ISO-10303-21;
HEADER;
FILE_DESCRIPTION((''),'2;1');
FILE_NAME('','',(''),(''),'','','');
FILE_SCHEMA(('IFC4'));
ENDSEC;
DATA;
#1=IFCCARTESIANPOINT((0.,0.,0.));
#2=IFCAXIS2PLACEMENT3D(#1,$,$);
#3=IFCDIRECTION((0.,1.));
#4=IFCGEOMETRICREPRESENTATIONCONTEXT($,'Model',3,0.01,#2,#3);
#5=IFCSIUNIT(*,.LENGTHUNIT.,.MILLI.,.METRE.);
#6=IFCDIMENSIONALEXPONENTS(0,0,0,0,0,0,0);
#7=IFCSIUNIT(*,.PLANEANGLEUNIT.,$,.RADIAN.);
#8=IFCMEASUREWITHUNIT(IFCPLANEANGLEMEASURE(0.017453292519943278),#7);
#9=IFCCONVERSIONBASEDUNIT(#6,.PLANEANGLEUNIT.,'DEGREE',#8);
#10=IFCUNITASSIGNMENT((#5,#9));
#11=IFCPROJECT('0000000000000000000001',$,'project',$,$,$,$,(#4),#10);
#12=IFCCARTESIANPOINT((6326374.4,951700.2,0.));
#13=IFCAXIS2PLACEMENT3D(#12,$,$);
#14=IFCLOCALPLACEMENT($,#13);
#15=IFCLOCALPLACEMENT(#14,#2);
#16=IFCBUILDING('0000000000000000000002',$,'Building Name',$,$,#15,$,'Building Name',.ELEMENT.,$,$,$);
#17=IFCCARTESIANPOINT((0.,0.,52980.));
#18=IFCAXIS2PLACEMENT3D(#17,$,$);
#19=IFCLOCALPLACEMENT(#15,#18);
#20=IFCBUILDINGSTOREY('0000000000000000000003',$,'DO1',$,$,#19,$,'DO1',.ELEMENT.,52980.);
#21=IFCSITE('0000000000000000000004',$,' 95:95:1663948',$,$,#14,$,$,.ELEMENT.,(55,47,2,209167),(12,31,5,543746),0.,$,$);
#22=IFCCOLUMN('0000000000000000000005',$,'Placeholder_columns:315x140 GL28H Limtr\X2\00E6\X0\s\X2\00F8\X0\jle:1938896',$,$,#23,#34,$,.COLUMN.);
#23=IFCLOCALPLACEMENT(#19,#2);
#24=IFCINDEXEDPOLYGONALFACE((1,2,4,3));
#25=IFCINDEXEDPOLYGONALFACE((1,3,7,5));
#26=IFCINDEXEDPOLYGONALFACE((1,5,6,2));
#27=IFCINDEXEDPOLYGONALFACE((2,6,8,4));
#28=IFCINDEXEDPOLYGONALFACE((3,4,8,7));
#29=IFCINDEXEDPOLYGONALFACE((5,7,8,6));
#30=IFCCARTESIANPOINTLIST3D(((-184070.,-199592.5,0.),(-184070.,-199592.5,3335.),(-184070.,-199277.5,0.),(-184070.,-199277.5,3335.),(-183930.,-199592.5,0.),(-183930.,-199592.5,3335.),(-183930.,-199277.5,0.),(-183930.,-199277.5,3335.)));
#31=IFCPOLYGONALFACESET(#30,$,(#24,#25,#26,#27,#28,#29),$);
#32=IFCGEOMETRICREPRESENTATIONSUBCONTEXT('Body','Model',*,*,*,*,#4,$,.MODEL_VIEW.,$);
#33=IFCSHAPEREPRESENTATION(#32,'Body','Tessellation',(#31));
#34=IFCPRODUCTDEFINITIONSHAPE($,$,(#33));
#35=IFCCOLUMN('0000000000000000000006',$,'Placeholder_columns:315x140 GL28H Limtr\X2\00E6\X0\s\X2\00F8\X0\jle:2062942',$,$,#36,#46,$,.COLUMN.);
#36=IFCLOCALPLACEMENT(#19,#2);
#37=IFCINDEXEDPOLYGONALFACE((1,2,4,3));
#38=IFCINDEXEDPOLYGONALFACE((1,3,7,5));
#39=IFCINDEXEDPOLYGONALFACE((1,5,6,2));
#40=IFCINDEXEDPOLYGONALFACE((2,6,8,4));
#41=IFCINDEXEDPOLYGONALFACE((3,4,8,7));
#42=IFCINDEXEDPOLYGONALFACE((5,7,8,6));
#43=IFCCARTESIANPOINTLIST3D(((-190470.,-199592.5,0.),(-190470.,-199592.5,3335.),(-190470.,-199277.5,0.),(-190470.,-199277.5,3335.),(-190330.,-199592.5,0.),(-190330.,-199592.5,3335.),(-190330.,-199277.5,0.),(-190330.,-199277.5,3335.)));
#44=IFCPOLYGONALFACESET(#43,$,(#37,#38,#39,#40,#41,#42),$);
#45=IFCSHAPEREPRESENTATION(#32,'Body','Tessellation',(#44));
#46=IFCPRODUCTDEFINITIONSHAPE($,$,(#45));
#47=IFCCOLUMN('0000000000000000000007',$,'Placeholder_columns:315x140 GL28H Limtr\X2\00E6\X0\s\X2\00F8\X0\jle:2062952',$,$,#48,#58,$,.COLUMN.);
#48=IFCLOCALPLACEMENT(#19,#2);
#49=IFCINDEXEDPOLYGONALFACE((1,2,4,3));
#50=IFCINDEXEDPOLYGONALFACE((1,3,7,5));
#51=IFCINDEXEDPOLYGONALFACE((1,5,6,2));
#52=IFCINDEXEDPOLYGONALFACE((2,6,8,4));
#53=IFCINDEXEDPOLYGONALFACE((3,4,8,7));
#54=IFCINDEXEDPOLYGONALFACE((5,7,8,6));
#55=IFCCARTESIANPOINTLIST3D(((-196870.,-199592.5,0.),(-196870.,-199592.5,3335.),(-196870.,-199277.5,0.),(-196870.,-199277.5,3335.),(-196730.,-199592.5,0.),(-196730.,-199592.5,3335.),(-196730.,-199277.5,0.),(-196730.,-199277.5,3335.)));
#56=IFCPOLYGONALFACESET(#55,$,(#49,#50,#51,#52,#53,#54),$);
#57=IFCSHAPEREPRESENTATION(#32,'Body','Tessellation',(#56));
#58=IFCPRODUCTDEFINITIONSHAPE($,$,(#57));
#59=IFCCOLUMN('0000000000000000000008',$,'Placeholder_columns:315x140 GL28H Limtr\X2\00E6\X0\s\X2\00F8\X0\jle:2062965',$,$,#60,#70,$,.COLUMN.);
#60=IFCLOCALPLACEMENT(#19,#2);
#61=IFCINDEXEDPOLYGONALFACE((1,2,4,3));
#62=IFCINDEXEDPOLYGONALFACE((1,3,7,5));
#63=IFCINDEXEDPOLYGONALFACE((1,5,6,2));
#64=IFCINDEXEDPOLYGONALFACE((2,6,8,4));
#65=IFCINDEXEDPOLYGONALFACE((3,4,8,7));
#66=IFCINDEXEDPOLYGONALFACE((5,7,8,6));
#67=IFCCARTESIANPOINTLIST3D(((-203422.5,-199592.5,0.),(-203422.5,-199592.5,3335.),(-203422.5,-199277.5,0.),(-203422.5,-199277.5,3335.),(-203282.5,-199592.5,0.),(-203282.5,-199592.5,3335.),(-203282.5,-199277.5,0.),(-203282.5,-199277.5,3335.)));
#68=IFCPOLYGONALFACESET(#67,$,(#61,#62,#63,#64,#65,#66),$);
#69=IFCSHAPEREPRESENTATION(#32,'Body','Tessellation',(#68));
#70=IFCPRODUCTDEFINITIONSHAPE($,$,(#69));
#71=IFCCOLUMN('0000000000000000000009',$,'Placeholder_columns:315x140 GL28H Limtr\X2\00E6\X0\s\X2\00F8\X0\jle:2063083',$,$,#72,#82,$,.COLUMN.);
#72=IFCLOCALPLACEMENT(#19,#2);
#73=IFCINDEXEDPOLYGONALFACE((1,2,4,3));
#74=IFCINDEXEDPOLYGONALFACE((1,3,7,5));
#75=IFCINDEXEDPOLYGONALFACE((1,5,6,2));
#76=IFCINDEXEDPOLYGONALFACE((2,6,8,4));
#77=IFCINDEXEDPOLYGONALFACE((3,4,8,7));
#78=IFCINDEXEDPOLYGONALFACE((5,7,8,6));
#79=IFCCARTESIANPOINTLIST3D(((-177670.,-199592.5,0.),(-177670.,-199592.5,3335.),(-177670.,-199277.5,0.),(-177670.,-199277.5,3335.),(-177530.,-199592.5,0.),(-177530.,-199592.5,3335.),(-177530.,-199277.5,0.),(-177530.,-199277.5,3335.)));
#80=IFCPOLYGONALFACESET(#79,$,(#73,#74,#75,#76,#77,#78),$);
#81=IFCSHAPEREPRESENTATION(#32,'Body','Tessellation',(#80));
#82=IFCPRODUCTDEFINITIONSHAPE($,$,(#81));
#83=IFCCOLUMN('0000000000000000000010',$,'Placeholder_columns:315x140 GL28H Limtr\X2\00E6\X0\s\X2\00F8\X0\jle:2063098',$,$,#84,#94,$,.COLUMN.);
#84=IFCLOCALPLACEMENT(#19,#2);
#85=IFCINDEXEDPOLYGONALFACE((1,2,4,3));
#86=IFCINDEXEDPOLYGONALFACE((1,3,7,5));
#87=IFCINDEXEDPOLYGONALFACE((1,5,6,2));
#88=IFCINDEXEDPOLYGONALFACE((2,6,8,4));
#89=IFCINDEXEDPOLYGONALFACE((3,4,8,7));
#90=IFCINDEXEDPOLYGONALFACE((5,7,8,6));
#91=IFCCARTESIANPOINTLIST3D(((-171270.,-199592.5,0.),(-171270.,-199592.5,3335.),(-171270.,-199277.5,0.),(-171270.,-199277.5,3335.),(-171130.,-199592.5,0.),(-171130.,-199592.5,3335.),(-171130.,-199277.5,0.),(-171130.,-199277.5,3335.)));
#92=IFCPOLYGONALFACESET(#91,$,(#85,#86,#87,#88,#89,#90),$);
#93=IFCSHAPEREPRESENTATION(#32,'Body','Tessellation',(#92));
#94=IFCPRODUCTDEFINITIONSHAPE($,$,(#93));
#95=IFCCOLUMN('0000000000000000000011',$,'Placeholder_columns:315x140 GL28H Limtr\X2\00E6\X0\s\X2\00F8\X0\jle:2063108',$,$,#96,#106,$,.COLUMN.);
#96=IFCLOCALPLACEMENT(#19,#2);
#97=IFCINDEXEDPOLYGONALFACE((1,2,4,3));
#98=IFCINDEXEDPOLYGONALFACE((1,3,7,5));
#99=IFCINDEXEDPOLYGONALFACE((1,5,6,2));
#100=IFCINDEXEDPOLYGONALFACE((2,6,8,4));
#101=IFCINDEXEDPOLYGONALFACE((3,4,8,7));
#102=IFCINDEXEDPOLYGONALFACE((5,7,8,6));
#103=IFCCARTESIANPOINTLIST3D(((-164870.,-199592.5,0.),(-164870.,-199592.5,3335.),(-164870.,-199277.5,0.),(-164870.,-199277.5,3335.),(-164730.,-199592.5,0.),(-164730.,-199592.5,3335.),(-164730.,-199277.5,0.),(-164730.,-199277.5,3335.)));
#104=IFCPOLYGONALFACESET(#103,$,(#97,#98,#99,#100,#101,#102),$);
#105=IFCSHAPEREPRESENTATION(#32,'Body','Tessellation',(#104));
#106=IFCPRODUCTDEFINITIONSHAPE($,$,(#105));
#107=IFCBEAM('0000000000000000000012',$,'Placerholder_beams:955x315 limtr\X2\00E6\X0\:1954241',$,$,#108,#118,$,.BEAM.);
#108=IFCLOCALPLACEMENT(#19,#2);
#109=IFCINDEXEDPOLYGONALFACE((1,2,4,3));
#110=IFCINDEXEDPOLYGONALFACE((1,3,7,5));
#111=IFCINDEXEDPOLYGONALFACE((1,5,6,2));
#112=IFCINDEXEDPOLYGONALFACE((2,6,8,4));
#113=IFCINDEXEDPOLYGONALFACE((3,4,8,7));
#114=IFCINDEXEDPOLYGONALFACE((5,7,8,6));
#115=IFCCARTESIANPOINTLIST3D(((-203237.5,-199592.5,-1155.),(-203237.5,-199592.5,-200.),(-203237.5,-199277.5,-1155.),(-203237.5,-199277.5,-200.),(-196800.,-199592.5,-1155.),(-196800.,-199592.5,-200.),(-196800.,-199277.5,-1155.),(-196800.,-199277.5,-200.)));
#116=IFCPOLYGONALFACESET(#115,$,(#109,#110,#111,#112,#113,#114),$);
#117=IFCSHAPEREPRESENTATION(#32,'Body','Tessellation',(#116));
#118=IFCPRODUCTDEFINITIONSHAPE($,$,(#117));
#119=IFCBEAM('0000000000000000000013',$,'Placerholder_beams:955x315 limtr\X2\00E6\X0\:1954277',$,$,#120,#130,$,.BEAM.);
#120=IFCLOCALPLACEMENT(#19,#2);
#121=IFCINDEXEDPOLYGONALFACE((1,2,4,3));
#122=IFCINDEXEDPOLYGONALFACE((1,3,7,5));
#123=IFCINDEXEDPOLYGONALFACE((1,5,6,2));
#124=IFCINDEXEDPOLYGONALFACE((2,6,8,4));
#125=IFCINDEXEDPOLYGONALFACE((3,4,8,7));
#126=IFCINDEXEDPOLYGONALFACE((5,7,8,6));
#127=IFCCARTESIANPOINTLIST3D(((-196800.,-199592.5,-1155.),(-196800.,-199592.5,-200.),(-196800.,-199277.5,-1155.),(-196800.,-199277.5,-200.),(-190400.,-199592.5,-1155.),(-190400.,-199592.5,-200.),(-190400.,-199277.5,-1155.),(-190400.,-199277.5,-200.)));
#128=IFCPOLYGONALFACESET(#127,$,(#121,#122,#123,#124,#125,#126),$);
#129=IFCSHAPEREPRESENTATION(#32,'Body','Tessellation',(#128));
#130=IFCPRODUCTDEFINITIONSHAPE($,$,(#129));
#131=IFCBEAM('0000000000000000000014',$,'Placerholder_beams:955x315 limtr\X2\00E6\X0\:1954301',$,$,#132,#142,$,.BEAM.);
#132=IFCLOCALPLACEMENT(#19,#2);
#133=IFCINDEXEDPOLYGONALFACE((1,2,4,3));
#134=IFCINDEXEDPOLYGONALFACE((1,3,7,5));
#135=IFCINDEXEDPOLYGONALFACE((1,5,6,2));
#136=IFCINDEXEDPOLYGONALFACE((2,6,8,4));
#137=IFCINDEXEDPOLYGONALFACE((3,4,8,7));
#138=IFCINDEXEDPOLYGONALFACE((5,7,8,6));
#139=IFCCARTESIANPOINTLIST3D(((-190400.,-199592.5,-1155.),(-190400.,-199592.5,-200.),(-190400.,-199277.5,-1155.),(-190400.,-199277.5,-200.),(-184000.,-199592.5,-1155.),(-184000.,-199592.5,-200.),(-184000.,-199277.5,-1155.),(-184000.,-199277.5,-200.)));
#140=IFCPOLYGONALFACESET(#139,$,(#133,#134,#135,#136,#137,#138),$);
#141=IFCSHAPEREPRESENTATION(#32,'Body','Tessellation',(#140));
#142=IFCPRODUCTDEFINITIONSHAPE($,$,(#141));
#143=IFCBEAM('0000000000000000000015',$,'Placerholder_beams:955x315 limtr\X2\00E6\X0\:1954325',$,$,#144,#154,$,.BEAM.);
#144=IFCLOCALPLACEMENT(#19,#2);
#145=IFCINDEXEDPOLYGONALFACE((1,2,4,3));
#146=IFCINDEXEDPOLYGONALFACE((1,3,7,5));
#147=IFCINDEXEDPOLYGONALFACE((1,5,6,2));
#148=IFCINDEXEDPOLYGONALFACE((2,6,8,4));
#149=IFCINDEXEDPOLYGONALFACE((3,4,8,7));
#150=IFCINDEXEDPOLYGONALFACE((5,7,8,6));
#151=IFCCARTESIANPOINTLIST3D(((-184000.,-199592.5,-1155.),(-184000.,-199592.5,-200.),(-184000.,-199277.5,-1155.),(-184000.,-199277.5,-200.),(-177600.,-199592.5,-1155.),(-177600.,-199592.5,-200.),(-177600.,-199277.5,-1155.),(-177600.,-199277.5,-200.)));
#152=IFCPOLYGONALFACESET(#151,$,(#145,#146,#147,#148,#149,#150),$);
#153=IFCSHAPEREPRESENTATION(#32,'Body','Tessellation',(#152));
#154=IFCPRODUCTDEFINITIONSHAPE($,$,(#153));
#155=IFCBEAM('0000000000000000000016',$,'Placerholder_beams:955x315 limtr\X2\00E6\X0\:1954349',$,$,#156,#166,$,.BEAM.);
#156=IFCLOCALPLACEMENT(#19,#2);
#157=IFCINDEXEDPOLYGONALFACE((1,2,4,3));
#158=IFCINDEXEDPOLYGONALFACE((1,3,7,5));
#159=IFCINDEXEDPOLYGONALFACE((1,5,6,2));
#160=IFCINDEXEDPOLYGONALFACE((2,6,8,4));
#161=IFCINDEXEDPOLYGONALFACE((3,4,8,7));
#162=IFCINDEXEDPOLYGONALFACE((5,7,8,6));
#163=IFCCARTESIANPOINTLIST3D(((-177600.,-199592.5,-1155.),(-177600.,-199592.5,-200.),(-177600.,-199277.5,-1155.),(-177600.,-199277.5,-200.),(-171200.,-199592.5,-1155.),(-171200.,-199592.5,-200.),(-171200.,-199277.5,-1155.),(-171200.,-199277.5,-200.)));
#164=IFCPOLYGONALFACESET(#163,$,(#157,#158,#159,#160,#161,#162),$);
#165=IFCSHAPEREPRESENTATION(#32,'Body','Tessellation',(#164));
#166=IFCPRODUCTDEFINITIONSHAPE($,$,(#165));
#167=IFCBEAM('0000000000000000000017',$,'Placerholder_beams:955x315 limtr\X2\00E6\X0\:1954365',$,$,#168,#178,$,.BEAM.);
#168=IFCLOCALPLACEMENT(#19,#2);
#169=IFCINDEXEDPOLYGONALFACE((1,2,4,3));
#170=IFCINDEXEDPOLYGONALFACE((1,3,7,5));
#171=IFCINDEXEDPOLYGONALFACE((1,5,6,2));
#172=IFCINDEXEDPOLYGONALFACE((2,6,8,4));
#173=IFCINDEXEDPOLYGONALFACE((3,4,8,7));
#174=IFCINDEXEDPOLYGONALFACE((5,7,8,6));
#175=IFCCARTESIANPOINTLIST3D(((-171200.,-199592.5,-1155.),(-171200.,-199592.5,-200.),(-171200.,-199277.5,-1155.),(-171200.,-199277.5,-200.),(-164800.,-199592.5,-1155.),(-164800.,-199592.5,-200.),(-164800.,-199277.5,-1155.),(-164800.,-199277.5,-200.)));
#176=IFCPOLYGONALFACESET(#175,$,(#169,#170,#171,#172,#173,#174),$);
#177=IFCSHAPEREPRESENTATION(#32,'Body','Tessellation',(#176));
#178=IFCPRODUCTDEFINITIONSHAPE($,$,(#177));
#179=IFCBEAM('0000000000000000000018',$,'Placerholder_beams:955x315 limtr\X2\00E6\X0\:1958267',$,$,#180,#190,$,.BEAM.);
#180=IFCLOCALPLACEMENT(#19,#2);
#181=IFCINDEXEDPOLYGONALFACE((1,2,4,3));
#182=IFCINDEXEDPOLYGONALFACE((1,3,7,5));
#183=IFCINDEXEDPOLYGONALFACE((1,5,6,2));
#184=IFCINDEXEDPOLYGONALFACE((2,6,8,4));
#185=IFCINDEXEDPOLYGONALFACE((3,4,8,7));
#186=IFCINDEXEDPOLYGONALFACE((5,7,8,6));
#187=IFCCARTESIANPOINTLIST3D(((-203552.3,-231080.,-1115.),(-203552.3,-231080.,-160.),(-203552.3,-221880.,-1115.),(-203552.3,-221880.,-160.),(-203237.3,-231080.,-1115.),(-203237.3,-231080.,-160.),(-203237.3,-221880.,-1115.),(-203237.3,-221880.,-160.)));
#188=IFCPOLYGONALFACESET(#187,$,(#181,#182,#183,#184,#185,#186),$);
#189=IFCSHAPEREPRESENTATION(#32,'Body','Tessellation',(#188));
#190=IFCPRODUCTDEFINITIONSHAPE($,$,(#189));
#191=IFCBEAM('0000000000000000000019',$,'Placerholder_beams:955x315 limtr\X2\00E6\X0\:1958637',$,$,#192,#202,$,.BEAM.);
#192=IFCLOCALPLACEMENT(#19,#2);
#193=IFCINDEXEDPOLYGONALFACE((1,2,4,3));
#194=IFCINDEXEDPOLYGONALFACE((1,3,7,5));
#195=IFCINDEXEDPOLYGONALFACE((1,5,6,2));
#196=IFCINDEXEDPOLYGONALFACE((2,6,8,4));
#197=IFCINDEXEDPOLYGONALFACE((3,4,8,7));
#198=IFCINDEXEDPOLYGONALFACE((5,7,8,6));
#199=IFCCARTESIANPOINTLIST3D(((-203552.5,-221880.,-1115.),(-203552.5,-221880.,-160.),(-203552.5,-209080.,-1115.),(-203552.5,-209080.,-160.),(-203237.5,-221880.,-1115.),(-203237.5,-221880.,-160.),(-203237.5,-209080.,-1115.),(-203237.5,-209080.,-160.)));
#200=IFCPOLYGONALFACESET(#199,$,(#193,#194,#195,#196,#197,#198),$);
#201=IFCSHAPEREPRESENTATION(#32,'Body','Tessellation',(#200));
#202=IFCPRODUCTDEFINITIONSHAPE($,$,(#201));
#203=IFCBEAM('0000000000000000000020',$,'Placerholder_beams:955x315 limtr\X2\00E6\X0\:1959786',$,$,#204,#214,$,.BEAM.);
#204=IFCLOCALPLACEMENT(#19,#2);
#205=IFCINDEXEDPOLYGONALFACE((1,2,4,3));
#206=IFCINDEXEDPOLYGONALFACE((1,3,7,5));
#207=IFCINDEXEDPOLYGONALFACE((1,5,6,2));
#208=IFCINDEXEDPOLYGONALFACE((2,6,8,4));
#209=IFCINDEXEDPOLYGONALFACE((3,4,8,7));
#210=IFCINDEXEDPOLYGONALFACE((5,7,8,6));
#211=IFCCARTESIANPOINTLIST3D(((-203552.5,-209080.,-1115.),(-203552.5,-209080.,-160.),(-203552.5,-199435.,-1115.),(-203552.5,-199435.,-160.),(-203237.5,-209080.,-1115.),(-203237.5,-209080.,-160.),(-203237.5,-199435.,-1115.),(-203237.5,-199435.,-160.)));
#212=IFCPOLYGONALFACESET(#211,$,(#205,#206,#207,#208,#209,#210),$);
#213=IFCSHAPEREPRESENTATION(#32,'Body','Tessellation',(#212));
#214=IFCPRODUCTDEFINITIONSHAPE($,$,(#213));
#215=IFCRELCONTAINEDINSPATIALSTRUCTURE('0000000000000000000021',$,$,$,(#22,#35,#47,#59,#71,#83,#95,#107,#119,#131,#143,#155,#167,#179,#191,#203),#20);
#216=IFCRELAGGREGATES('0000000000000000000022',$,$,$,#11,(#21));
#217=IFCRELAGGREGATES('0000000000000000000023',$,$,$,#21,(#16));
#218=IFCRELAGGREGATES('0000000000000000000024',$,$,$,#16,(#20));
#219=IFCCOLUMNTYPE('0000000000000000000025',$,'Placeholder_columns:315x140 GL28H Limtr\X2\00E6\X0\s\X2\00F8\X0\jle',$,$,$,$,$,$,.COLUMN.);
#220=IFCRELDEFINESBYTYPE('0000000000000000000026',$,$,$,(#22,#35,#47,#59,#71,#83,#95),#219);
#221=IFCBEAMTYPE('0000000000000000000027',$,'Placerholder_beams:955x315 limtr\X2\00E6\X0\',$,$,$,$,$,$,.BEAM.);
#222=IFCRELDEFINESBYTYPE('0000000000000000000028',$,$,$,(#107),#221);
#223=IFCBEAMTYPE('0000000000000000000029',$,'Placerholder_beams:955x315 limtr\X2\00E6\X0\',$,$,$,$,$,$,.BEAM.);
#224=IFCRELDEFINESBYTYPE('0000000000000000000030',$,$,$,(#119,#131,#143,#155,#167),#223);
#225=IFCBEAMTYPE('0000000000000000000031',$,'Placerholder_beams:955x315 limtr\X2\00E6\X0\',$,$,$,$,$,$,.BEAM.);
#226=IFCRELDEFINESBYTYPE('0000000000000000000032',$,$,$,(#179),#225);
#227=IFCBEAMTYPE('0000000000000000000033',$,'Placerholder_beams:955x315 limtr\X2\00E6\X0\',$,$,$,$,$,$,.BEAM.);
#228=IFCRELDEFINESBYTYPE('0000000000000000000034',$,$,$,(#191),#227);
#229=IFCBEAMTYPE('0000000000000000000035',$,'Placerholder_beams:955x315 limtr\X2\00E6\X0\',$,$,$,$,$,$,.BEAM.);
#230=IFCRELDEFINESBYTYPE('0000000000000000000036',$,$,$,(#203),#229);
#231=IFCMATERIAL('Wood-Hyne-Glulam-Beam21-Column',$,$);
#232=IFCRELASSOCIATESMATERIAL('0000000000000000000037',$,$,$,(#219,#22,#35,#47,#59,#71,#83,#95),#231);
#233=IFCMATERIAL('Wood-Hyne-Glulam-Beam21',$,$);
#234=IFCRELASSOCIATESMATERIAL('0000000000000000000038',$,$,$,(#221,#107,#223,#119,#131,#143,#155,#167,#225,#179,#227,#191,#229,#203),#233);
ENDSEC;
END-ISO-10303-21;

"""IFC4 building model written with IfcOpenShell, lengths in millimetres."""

from ifc_helpers import new_model, entity, si_unit, converted_unit, direction, frame, origin, place, context, subcontext, project, spatial, indexed_curve, outline, extrude, source, transform, mapped, material, type_object, type_shapes, element, save


model = new_model("IFC4")

# Units and contexts
model_context = context("Model", 3, precision=0.01, world=origin(), true_north=direction((0.0, 1.0)))
body_context = subcontext(model_context, "Body", "Model", "MODEL_VIEW")
ifc_project = project(units=[si_unit("LENGTHUNIT", "METRE", prefix="MILLI"), converted_unit("PLANEANGLEUNIT", "DEGREE", entity("IfcPlaneAngleMeasure", 0.017453292519943278), si_unit("PLANEANGLEUNIT", "RADIAN"), dimensions=[0, 0, 0, 0, 0, 0, 0])], contexts=[model_context])

# Site, building, storey
site_placement = place(None, frame((6326374.4, 951700.2, 0.0)))
site = spatial("IfcSite", under=ifc_project, at=site_placement, Name=" 95:95:1663948", CompositionType="ELEMENT", RefLatitude=(55, 47, 2, 209167), RefLongitude=(12, 31, 5, 543746), RefElevation=0.0)
building_placement = place(site_placement, origin())
building = spatial("IfcBuilding", under=site, at=building_placement, Name="Building Name", LongName="Building Name", CompositionType="ELEMENT")
storey_placement = place(building_placement, frame((0.0, 0.0, 52980.0)))
storey = spatial("IfcBuildingStorey", under=building, at=storey_placement, Name="DO1", LongName="DO1", CompositionType="ELEMENT", Elevation=52980.0)

# Columns
ifc_material_1 = material(Name="Wood-Hyne-Glulam-Beam21-Column")
column_type = type_object("IfcColumnType", Name="Placeholder_columns:315x140 GL28H Limtræsøjle", PredefinedType="COLUMN", material=ifc_material_1)
shared_shape_1 = source(origin(), body_context, "Body", "SweptSolid", [
    extrude(outline(indexed_curve([(-157.5, -70.0), (157.5, -70.0), (157.5, 70.0), (-157.5, 70.0), (-157.5, -70.0)], self_intersect=False)), frame((0.0, 0.0, 52980.0), z_axis=(0.0, 0.0, 1.0), x_axis=(-1.0, 0.0, 0.0)), (0.0, 0.0, 1.0), 3335.0),
])
type_shapes(column_type, [shared_shape_1])
for number, where, z_axis, x_axis, name in (
    (1, (-184000.0, -199435.0, -52980.0), (0.0, 0.0, 1.0), (0.0, -1.0, 0.0), "Placeholder_columns:315x140 GL28H Limtræsøjle:1938896"),
    (2, (-190400.0, -199435.0, -52980.0), (0.0, 0.0, 1.0), (0.0, -1.0, 0.0), "Placeholder_columns:315x140 GL28H Limtræsøjle:2062942"),
    (3, (-196800.0, -199435.0, -52980.0), (0.0, 0.0, 1.0), (0.0, -1.0, 0.0), "Placeholder_columns:315x140 GL28H Limtræsøjle:2062952"),
    (4, (-203352.5, -199435.0, -52980.0), (0.0, 0.0, 1.0), (0.0, -1.0, 0.0), "Placeholder_columns:315x140 GL28H Limtræsøjle:2062965"),
    (5, (-177600.0, -199435.0, -52980.0), (0.0, 0.0, 1.0), (0.0, -1.0, 0.0), "Placeholder_columns:315x140 GL28H Limtræsøjle:2063083"),
    (6, (-171200.0, -199435.0, -52980.0), (0.0, 0.0, 1.0), (0.0, -1.0, 0.0), "Placeholder_columns:315x140 GL28H Limtræsøjle:2063098"),
    (7, (-164800.0, -199435.0, -52980.0), (0.0, 0.0, 1.0), (0.0, -1.0, 0.0), "Placeholder_columns:315x140 GL28H Limtræsøjle:2063108"),
):
    element("IfcColumn", number, at=place(storey_placement, frame(where, z_axis=z_axis, x_axis=x_axis)), inside=storey, type_object=column_type, material=ifc_material_1, Name=name, PredefinedType="COLUMN", context=body_context, shape_type="MappedRepresentation", body=[
        mapped(shared_shape_1, transform((0.0, 0.0, 0.0), scale=1.0)),
    ])

# Beams
ifc_material_2 = material(Name="Wood-Hyne-Glulam-Beam21")
beam_type_1 = type_object("IfcBeamType", Name="Placerholder_beams:955x315 limtræ", PredefinedType="BEAM", material=ifc_material_2)
shared_shape_2 = source(origin(), body_context, "Body", "SweptSolid", [
    extrude(outline(indexed_curve([(-3218.8, -157.5), (3218.8, -157.5), (3218.8, 157.5), (-3218.8, 157.5), (-3218.8, -157.5)], self_intersect=False)), frame((-78.7, 0.0, -477.5)), (0.0, 0.0, 1.0), 955.0),
])
type_shapes(beam_type_1, [shared_shape_2])
beam_1_placement = place(storey_placement, frame((-200097.5, -199435.0, -677.5), z_axis=(0.0, 0.0, 1.0), x_axis=(-1.0, 0.0, 0.0)))
element("IfcBeam", 8, at=beam_1_placement, inside=storey, type_object=beam_type_1, material=ifc_material_2, Name="Placerholder_beams:955x315 limtræ:1954241", PredefinedType="BEAM", context=body_context, shape_type="MappedRepresentation", body=[
    mapped(shared_shape_2, transform((0.0, 0.0, 0.0), scale=1.0)),
])
beam_type_2 = type_object("IfcBeamType", Name="Placerholder_beams:955x315 limtræ", PredefinedType="BEAM", material=ifc_material_2)
shared_shape_3 = source(origin(), body_context, "Body", "SweptSolid", [
    extrude(outline(indexed_curve([(-3200.0, -157.5), (3200.0, -157.5), (3200.0, 157.5), (-3200.0, 157.5), (-3200.0, -157.5)], self_intersect=False)), frame((0.0, 0.0, -477.5)), (0.0, 0.0, 1.0), 955.0),
])
type_shapes(beam_type_2, [shared_shape_3])
for number, where, name in (
    (9, (-193600.0, -199435.0, -677.5), "Placerholder_beams:955x315 limtræ:1954277"),
    (10, (-187200.0, -199435.0, -677.5), "Placerholder_beams:955x315 limtræ:1954301"),
    (11, (-180800.0, -199435.0, -677.5), "Placerholder_beams:955x315 limtræ:1954325"),
    (12, (-174400.0, -199435.0, -677.5), "Placerholder_beams:955x315 limtræ:1954349"),
    (13, (-168000.0, -199435.0, -677.5), "Placerholder_beams:955x315 limtræ:1954365"),
):
    element("IfcBeam", number, at=place(storey_placement, frame(where)), inside=storey, type_object=beam_type_2, material=ifc_material_2, Name=name, PredefinedType="BEAM", context=body_context, shape_type="MappedRepresentation", body=[
        mapped(shared_shape_3, transform((0.0, 0.0, 0.0), scale=1.0)),
    ])
beam_type_3 = type_object("IfcBeamType", Name="Placerholder_beams:955x315 limtræ", PredefinedType="BEAM", material=ifc_material_2)
shared_shape_4 = source(origin(), body_context, "Body", "SweptSolid", [
    extrude(outline(indexed_curve([(-4600.0, -157.5), (4600.0, -157.5), (4600.0, 157.5), (-4600.0, 157.5), (-4600.0, -157.5)], self_intersect=False)), frame((0.0, 0.0, -477.5)), (0.0, 0.0, 1.0), 955.0),
])
type_shapes(beam_type_3, [shared_shape_4])
beam_2_placement = place(storey_placement, frame((-203394.8, -226480.0, -637.5), z_axis=(0.0, 0.0, 1.0), x_axis=(0.0, 1.0, 0.0)))
element("IfcBeam", 14, at=beam_2_placement, inside=storey, type_object=beam_type_3, material=ifc_material_2, Name="Placerholder_beams:955x315 limtræ:1958267", PredefinedType="BEAM", context=body_context, shape_type="MappedRepresentation", body=[
    mapped(shared_shape_4, transform((0.0, 0.0, 0.0), scale=1.0)),
])
beam_type_4 = type_object("IfcBeamType", Name="Placerholder_beams:955x315 limtræ", PredefinedType="BEAM", material=ifc_material_2)
shared_shape_5 = source(origin(), body_context, "Body", "SweptSolid", [
    extrude(outline(indexed_curve([(-6400.0, -157.5), (6400.0, -157.5), (6400.0, 157.5), (-6400.0, 157.5), (-6400.0, -157.5)], self_intersect=False)), frame((0.0, 0.0, -477.5)), (0.0, 0.0, 1.0), 955.0),
])
type_shapes(beam_type_4, [shared_shape_5])
beam_3_placement = place(storey_placement, frame((-203395.0, -215480.0, -637.5), z_axis=(0.0, 0.0, 1.0), x_axis=(0.0, 1.0, 0.0)))
element("IfcBeam", 15, at=beam_3_placement, inside=storey, type_object=beam_type_4, material=ifc_material_2, Name="Placerholder_beams:955x315 limtræ:1958637", PredefinedType="BEAM", context=body_context, shape_type="MappedRepresentation", body=[
    mapped(shared_shape_5, transform((0.0, 0.0, 0.0), scale=1.0)),
])
beam_type_5 = type_object("IfcBeamType", Name="Placerholder_beams:955x315 limtræ", PredefinedType="BEAM", material=ifc_material_2)
shared_shape_6 = source(origin(), body_context, "Body", "SweptSolid", [
    extrude(outline(indexed_curve([(-4822.5, -157.5), (4822.5, -157.5), (4822.5, 157.5), (-4822.5, 157.5), (-4822.5, -157.5)], self_intersect=False)), frame((0.0, 0.0, -477.5)), (0.0, 0.0, 1.0), 955.0),
])
type_shapes(beam_type_5, [shared_shape_6])
beam_4_placement = place(storey_placement, frame((-203395.0, -204257.5, -637.5), z_axis=(0.0, 0.0, 1.0), x_axis=(0.0, 1.0, 0.0)))
element("IfcBeam", 16, at=beam_4_placement, inside=storey, type_object=beam_type_5, material=ifc_material_2, Name="Placerholder_beams:955x315 limtræ:1959786", PredefinedType="BEAM", context=body_context, shape_type="MappedRepresentation", body=[
    mapped(shared_shape_6, transform((0.0, 0.0, 0.0), scale=1.0)),
])

save(model, "model.ifc")
